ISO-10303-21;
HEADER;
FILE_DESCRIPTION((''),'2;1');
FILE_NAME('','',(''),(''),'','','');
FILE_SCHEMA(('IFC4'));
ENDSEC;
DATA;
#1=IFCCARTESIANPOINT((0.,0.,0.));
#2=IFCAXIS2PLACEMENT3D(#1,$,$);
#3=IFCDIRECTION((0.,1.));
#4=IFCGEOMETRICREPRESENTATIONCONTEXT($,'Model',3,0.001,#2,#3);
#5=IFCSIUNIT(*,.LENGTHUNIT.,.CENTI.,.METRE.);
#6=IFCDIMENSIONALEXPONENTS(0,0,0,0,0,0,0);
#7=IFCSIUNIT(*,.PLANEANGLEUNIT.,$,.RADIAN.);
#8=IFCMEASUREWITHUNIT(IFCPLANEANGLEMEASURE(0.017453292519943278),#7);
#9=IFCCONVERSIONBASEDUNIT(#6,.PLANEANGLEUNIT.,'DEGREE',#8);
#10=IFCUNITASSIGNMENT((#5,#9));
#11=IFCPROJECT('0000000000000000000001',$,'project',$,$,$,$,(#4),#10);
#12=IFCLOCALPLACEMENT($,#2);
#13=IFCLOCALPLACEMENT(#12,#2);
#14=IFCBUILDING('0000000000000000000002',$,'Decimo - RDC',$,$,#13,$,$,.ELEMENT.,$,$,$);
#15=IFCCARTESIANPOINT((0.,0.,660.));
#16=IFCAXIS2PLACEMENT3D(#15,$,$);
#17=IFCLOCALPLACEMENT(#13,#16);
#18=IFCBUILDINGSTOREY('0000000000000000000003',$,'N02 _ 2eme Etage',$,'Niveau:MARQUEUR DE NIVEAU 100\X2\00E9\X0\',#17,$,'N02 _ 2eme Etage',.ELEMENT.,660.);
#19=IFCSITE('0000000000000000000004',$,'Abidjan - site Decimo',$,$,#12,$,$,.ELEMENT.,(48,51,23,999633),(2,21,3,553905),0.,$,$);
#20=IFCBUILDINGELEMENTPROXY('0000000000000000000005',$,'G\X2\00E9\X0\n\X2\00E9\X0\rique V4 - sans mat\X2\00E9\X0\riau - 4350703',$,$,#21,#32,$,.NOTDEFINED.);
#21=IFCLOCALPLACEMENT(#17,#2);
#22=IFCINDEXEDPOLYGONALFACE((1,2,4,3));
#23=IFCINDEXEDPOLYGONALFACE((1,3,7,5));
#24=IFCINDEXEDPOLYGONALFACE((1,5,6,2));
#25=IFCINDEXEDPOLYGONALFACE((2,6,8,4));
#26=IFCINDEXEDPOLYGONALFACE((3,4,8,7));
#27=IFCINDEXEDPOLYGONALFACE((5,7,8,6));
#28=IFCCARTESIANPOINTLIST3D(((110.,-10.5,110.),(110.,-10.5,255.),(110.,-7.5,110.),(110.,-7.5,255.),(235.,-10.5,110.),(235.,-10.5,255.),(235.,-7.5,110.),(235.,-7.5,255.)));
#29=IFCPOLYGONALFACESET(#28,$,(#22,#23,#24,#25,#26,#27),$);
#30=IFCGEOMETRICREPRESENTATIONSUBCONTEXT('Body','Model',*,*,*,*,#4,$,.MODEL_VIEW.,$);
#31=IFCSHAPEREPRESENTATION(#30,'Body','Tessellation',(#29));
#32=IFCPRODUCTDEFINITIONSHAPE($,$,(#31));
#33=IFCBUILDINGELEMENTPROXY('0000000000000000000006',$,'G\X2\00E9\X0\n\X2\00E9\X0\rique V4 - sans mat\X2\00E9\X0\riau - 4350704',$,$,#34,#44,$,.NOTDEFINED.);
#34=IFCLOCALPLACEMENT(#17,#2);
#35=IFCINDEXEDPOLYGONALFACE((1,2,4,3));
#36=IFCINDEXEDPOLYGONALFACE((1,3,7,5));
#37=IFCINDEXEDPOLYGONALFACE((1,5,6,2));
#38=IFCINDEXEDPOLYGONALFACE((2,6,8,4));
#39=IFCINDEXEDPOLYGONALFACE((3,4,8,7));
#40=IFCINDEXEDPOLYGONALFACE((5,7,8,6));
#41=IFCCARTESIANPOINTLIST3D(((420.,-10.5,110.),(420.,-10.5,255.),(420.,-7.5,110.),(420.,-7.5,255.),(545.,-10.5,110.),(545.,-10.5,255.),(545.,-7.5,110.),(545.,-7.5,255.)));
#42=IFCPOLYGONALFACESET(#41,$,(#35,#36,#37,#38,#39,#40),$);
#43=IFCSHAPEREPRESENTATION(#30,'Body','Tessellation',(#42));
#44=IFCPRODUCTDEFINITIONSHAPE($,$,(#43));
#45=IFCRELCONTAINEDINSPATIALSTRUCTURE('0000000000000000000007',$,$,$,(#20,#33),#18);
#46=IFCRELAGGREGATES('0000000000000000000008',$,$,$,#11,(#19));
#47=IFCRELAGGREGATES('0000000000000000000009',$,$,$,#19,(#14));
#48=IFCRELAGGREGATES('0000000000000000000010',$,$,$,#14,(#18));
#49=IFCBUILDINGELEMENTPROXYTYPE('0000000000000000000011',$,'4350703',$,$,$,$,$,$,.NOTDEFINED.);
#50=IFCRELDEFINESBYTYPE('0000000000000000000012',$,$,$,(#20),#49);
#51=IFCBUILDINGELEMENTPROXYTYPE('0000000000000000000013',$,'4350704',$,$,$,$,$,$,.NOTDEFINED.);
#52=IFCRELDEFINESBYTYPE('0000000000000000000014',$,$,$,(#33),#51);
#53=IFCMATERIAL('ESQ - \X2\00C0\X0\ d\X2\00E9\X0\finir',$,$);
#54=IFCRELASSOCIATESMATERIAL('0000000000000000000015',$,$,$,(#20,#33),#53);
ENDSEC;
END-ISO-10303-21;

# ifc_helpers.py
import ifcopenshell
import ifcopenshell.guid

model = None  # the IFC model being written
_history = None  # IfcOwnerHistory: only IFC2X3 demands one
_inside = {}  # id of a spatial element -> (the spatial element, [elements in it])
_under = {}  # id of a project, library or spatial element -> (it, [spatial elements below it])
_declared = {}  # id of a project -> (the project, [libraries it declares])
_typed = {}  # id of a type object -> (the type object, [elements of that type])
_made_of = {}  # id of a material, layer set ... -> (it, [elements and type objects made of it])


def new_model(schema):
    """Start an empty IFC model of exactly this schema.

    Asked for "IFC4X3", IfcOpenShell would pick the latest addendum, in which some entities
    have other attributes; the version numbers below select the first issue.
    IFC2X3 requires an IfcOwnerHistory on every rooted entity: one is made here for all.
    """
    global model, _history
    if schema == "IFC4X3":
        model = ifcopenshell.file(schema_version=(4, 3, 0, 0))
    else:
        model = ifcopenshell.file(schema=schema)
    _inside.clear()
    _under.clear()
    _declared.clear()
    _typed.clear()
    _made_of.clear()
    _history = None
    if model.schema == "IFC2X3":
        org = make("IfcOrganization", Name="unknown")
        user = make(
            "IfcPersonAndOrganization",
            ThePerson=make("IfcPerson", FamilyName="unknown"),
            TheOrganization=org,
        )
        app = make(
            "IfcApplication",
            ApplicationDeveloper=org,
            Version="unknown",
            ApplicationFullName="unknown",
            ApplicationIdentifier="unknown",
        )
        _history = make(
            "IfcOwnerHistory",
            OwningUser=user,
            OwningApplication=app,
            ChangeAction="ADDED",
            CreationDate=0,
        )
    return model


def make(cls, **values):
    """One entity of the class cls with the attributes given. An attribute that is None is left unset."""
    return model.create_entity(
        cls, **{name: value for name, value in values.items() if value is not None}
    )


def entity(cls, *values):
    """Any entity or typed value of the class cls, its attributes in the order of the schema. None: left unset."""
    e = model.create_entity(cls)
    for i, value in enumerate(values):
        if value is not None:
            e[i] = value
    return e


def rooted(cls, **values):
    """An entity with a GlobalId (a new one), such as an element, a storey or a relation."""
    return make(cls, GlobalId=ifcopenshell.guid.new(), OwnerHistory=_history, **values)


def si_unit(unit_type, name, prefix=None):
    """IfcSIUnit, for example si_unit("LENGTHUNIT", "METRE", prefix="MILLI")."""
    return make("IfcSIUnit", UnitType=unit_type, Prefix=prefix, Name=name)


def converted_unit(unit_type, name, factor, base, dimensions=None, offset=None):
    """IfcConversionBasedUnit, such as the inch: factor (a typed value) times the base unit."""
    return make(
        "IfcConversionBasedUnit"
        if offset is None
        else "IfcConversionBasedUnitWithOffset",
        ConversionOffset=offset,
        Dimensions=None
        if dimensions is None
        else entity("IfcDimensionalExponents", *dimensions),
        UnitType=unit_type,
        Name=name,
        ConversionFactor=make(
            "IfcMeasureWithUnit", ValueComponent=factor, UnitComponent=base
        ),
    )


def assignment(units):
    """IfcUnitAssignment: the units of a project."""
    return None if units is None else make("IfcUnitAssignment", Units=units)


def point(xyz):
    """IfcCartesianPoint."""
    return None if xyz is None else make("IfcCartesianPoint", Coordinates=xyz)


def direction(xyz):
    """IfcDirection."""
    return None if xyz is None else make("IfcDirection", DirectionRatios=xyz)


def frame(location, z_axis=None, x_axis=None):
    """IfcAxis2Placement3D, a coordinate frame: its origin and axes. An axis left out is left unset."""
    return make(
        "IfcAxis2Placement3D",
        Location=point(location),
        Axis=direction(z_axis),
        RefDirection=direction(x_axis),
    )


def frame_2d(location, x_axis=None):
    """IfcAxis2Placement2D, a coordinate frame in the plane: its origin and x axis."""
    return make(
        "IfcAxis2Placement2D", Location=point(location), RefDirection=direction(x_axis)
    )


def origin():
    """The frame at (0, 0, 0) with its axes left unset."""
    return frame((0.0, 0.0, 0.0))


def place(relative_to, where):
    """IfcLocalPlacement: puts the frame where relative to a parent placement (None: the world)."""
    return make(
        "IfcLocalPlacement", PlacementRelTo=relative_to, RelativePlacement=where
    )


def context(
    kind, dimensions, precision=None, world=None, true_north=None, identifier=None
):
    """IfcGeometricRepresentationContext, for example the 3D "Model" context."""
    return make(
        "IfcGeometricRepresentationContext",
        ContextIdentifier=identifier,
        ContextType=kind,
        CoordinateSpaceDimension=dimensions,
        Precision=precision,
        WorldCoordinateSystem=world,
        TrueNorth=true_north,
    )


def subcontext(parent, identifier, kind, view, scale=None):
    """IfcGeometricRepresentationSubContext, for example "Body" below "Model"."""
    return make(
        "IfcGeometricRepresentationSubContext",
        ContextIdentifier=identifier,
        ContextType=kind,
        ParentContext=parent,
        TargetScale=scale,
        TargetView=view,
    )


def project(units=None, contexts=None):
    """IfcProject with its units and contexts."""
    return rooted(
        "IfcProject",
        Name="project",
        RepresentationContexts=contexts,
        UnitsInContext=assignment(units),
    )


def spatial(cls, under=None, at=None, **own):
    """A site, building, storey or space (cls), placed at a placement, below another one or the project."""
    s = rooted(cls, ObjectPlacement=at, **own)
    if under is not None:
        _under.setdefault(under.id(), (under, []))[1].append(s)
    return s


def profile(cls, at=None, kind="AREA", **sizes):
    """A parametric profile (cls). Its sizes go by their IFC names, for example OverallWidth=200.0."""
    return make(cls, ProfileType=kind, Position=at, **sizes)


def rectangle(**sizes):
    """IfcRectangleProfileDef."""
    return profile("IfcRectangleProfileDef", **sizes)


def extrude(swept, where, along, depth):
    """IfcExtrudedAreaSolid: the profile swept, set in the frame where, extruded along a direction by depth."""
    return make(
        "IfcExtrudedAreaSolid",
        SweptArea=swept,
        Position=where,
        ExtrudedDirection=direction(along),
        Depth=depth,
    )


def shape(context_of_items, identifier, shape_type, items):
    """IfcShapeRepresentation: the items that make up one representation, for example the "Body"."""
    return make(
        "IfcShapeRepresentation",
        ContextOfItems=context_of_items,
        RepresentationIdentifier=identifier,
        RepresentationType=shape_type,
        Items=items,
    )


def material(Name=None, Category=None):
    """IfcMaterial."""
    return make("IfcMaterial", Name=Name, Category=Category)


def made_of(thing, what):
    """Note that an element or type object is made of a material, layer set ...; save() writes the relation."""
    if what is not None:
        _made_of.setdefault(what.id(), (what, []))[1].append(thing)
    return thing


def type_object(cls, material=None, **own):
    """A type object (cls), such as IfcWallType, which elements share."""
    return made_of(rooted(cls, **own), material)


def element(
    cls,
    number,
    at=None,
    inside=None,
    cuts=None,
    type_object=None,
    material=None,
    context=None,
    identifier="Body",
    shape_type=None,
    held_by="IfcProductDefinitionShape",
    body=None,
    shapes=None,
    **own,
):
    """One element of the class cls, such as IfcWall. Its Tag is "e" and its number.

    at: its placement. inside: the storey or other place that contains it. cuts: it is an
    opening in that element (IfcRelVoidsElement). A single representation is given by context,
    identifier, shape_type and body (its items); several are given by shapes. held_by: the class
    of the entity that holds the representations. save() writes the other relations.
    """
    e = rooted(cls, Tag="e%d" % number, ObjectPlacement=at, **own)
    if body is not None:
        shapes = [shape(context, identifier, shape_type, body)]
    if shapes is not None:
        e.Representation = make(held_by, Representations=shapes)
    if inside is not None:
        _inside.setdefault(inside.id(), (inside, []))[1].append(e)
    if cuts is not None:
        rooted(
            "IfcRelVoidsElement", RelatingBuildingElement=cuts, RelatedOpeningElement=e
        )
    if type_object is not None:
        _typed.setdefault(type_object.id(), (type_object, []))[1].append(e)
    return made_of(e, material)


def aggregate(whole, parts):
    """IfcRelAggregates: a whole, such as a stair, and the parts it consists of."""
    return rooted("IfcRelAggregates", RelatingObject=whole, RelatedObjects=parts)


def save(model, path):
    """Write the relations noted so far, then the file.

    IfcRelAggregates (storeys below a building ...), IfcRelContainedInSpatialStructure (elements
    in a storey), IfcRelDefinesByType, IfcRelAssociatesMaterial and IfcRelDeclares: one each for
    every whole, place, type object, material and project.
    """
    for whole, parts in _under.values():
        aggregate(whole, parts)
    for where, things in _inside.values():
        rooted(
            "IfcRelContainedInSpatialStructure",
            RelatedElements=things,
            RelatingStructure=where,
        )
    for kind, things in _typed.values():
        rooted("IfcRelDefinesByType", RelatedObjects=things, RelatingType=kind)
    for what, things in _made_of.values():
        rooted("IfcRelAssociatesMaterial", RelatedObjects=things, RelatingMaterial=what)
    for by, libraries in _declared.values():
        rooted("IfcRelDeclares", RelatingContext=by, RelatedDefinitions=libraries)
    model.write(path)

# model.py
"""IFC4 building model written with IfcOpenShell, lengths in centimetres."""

from ifc_helpers import new_model, entity, si_unit, converted_unit, direction, frame, frame_2d, origin, place, context, subcontext, project, spatial, rectangle, extrude, material, type_object, element, save


model = new_model("IFC4")

# Units and contexts
model_context = context("Model", 3, precision=0.001, world=origin(), true_north=direction((0.0, 1.0)))
body_context = subcontext(model_context, "Body", "Model", "MODEL_VIEW")
ifc_project = project(units=[si_unit("LENGTHUNIT", "METRE", prefix="CENTI"), converted_unit("PLANEANGLEUNIT", "DEGREE", entity("IfcPlaneAngleMeasure", 0.017453292519943278), si_unit("PLANEANGLEUNIT", "RADIAN"), dimensions=[0, 0, 0, 0, 0, 0, 0])], contexts=[model_context])

# Site, building, storey
site_placement = place(None, origin())
site = spatial("IfcSite", under=ifc_project, at=site_placement, Name="Abidjan - site Decimo", CompositionType="ELEMENT", RefLatitude=(48, 51, 23, 999633), RefLongitude=(2, 21, 3, 553905), RefElevation=0.0)
building_placement = place(site_placement, origin())
building = spatial("IfcBuilding", under=site, at=building_placement, Name="Decimo - RDC", CompositionType="ELEMENT")
storey_placement = place(building_placement, frame((0.0, 0.0, 660.0)))
storey = spatial("IfcBuildingStorey", under=building, at=storey_placement, Name="N02 _ 2eme Etage", ObjectType="Niveau:MARQUEUR DE NIVEAU 100é", LongName="N02 _ 2eme Etage", CompositionType="ELEMENT", Elevation=660.0)

# Building element proxies
ifc_material = material(Name="ESQ - À définir")
building_element_proxy_type_1 = type_object("IfcBuildingElementProxyType", Name="4350703", PredefinedType="NOTDEFINED")
proxy_1_placement = place(storey_placement, origin())
element("IfcBuildingElementProxy", 1, at=proxy_1_placement, inside=storey, type_object=building_element_proxy_type_1, material=ifc_material, Name="Générique V4 - sans matériau - 4350703", PredefinedType="NOTDEFINED", context=body_context, shape_type="SweptSolid", body=[
    extrude(rectangle(XDim=125.0, YDim=3.0, at=frame_2d((0.0, 0.0), x_axis=(1.0, 0.0))), frame((172.5, -9.0, 110.0)), (0.0, 0.0, 1.0), 145.0),
])
building_element_proxy_type_2 = type_object("IfcBuildingElementProxyType", Name="4350704", PredefinedType="NOTDEFINED")
proxy_2_placement = place(storey_placement, origin())
element("IfcBuildingElementProxy", 2, at=proxy_2_placement, inside=storey, type_object=building_element_proxy_type_2, material=ifc_material, Name="Générique V4 - sans matériau - 4350704", PredefinedType="NOTDEFINED", context=body_context, shape_type="SweptSolid", body=[
    extrude(rectangle(XDim=125.0, YDim=3.0, at=frame_2d((0.0, 0.0), x_axis=(1.0, 0.0))), frame((482.5, -9.0, 110.0)), (0.0, 0.0, 1.0), 145.0),
])

save(model, "model.ifc")
